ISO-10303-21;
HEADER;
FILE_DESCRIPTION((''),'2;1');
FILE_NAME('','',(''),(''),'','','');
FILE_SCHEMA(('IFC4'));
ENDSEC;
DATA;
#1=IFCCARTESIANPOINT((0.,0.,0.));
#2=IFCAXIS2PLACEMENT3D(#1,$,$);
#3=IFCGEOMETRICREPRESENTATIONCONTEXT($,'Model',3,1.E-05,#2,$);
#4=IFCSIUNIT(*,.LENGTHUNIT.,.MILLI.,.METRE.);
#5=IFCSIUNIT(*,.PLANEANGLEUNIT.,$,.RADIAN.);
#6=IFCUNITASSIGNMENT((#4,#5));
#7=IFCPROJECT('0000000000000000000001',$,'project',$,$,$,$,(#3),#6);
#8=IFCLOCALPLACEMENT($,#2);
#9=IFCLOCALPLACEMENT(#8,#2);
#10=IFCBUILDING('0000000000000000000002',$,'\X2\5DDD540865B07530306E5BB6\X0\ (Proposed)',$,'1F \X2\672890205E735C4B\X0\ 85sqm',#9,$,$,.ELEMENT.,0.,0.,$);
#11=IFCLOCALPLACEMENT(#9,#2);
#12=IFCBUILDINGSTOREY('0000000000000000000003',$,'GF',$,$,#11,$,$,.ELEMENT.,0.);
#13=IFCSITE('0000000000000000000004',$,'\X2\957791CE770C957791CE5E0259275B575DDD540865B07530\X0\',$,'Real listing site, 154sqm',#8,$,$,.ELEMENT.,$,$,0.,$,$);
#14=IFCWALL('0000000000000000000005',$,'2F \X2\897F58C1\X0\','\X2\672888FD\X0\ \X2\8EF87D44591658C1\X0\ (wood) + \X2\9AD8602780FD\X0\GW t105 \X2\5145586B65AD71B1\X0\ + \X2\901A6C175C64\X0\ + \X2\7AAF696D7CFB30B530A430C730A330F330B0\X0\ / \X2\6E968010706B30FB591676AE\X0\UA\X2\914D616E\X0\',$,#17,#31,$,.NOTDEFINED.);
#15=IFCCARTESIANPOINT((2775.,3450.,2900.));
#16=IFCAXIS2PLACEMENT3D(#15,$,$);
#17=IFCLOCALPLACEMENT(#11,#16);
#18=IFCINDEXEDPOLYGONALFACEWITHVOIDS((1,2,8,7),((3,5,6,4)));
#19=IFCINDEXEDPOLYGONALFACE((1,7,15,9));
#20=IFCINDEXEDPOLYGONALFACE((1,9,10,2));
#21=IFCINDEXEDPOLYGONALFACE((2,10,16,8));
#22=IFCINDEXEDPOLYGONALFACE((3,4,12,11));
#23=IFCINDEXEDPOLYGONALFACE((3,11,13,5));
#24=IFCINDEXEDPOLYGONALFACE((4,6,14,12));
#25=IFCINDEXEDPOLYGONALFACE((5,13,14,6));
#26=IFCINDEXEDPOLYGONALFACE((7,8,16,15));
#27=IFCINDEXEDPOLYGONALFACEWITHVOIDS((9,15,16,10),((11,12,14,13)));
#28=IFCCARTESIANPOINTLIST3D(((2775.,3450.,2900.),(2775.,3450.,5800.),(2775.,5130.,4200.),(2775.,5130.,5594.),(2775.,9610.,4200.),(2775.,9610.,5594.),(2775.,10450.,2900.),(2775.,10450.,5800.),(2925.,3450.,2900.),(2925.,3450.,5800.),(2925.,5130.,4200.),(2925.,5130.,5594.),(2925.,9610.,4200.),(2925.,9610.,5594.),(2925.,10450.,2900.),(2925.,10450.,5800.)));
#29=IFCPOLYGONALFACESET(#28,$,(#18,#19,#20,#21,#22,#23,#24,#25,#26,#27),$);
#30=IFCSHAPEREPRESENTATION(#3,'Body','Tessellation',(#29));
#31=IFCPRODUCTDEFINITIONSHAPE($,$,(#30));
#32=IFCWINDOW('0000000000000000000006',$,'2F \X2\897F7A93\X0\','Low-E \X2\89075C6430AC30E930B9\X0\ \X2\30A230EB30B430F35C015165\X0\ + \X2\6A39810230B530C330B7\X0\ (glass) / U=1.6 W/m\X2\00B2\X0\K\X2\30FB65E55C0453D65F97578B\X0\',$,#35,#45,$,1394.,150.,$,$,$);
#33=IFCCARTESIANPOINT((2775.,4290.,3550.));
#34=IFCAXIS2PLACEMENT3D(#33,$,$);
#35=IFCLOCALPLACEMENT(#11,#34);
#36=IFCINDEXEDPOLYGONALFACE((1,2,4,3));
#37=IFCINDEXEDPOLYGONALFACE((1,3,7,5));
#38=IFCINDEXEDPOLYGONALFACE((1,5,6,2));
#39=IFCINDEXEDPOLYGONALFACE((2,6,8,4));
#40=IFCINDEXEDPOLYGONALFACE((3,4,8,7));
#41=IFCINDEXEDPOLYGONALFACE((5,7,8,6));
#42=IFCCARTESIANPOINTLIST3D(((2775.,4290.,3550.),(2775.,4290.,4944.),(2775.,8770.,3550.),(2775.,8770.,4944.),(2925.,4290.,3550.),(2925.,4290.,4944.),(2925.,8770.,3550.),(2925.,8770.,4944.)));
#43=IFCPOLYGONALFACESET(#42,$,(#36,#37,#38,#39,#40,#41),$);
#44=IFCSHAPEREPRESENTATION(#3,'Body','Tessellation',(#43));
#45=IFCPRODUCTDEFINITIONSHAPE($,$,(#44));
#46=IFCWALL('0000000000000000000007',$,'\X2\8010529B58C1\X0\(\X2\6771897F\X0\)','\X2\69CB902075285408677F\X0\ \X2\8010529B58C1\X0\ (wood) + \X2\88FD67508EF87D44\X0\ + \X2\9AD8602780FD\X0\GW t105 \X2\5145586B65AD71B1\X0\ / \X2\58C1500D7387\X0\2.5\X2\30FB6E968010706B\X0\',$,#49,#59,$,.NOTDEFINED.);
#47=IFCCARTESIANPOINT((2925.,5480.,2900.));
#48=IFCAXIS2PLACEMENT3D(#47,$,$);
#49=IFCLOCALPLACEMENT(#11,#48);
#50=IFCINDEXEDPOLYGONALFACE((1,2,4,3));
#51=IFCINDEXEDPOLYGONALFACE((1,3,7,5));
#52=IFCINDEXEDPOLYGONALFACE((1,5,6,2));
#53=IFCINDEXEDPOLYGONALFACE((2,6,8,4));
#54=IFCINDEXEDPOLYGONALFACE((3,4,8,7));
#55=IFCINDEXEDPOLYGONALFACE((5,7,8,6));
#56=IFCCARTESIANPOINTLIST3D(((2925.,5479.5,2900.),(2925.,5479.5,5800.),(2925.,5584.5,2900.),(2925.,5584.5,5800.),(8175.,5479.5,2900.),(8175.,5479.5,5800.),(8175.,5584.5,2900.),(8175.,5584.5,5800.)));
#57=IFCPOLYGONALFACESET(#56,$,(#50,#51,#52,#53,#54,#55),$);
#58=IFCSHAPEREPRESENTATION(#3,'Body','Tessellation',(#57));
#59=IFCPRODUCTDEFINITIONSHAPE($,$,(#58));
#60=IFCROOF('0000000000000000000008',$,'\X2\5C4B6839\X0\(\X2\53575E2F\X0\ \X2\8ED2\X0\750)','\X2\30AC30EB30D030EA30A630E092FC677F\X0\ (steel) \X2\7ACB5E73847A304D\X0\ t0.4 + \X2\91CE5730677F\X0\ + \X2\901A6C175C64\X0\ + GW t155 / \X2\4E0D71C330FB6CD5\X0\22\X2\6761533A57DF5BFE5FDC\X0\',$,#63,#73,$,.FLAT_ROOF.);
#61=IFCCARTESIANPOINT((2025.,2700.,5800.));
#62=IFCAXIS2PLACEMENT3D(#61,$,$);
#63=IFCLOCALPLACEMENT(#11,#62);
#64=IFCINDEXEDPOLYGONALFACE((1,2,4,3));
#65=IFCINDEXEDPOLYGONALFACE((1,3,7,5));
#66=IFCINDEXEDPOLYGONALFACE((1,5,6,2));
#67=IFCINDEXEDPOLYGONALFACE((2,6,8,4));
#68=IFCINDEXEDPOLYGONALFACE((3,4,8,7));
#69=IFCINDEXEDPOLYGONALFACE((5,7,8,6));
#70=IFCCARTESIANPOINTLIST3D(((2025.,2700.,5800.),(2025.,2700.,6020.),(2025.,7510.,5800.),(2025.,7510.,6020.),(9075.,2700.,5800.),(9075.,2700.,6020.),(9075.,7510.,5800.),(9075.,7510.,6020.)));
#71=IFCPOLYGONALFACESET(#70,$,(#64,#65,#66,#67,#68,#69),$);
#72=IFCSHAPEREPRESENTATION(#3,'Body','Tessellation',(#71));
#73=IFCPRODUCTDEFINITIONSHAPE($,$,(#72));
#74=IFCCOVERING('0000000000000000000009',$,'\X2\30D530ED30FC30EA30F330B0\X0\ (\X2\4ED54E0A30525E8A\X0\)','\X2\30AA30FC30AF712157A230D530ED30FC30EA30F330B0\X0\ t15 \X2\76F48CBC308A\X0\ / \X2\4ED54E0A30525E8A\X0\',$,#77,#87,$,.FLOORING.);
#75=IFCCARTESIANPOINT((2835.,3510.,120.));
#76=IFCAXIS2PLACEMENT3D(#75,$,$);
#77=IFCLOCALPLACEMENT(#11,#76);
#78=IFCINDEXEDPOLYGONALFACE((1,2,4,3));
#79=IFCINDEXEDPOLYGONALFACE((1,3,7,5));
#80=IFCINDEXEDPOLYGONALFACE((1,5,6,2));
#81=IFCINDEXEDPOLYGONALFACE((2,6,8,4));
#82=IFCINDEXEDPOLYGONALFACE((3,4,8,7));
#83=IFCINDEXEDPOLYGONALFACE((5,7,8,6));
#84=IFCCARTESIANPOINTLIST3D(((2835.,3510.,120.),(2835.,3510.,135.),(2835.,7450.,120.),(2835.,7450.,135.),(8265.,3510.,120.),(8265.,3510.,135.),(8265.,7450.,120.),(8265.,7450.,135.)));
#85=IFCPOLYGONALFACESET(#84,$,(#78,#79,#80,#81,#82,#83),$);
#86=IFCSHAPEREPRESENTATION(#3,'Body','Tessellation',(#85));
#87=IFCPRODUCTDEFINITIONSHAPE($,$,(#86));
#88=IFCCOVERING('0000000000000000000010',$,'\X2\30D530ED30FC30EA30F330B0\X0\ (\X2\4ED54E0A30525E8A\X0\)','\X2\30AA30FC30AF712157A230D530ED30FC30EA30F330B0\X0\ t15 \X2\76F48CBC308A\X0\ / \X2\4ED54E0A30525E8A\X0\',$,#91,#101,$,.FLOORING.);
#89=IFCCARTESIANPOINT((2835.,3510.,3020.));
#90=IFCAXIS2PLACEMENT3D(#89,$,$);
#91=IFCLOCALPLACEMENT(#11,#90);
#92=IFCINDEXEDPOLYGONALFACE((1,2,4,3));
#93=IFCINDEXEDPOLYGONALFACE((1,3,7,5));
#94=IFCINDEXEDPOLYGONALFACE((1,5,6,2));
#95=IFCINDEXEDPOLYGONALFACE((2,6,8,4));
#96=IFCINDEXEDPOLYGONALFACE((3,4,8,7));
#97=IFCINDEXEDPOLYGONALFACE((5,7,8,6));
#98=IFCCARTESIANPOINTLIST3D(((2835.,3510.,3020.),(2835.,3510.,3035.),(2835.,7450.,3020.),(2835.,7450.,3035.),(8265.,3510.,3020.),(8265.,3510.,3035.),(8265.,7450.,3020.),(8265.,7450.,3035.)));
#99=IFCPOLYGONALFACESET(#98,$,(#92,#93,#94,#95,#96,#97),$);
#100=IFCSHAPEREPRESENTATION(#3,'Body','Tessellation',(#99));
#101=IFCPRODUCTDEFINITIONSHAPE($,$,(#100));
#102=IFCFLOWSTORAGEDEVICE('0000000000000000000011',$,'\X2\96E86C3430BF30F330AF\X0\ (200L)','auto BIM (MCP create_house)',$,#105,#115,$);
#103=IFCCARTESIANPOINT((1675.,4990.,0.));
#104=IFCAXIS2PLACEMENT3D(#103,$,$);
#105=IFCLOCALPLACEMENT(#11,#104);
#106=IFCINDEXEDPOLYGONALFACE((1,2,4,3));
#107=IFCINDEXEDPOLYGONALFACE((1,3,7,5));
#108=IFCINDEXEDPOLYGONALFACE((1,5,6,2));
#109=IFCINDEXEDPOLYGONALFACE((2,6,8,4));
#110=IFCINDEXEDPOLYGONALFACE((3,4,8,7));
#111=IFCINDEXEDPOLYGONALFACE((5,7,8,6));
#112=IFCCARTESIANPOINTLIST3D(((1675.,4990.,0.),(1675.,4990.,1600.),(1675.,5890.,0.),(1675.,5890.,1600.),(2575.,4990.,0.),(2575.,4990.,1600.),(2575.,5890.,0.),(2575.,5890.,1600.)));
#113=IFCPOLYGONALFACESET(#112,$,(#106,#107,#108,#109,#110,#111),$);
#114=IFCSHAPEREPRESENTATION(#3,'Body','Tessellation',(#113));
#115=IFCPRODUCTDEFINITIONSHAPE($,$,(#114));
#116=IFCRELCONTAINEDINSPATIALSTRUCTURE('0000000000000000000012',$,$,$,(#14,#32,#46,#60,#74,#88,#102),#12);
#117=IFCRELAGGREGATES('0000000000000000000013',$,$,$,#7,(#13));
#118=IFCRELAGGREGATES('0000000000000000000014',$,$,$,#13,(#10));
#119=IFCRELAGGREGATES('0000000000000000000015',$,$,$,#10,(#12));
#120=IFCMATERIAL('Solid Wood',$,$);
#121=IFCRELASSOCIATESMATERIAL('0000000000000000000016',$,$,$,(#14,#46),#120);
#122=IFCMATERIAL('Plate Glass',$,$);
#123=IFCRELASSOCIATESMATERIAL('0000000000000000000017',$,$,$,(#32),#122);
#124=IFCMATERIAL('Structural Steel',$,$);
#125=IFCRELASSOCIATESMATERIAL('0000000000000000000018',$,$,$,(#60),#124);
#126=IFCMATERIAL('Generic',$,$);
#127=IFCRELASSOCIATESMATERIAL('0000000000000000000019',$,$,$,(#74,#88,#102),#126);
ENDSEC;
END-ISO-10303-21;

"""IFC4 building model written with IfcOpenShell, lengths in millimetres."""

from ifc_helpers import new_model, si_unit, frame, frame_2d, origin, place, context, project, spatial, rectangle, extrude, material, element, fill, save


model = new_model("IFC4")

# Units and contexts
model_context = context("Model", 3, precision=1e-05, world=origin())
ifc_project = project(units=[si_unit("LENGTHUNIT", "METRE", prefix="MILLI"), si_unit("PLANEANGLEUNIT", "RADIAN")], contexts=[model_context])

# Site, building, storey
site_placement = place(None, origin())
site = spatial("IfcSite", under=ifc_project, at=site_placement, Name="長野県長野市大字川合新田", ObjectType="Real listing site, 154sqm", CompositionType="ELEMENT", RefElevation=0.0)
building_placement = place(site_placement, origin())
building = spatial("IfcBuilding", under=site, at=building_placement, Name="川合新田の家 (Proposed)", ObjectType="1F 木造平屋 85sqm", CompositionType="ELEMENT", ElevationOfRefHeight=0.0, ElevationOfTerrain=0.0)
storey_placement = place(building_placement, origin())
storey = spatial("IfcBuildingStorey", under=building, at=storey_placement, Name="GF", CompositionType="ELEMENT", Elevation=0.0)

# Shared definitions
ifc_material_1 = material(Name="Solid Wood")
ifc_material_2 = material(Name="Generic")

# Shared definitions
ifc_material_3 = material(Name="Plate Glass")

# Wall, opening, window
wall_1_placement = place(storey_placement, frame((2775.0, 3450.0, 2900.0)))
wall_1 = element("IfcWall", 1, at=wall_1_placement, inside=storey, material=ifc_material_1, Name="2F 西壁", Description="木製 軸組外壁 (wood) + 高性能GW t105 充填断熱 + 通気層 + 窯業系サイディング / 準耐火・外皮UA配慮", PredefinedType="NOTDEFINED", context=model_context, shape_type="SweptSolid", body=[
    extrude(rectangle(XDim=150.0, YDim=7000.0, at=frame_2d((75.0, 3500.0))), frame((2775.0, 3450.0, 2900.0)), (0.0, 0.0, 1.0), 2900.0),
])
opening_1_placement = place(storey_placement, frame((2775.0, 4290.0, 3550.0)))
opening_1 = element("IfcOpeningElement", 2, at=opening_1_placement, cuts=wall_1, PredefinedType="NOTDEFINED", context=model_context, shape_type="SweptSolid", body=[
    extrude(rectangle(XDim=150.0, YDim=4480.0, at=frame_2d((75.0, 2240.0))), frame((2775.0, 4290.0, 3550.0)), (0.0, 0.0, 1.0), 1394.0),
])
window_1_placement = place(storey_placement, frame((2775.0, 4290.0, 3550.0)))
window_1 = element("IfcWindow", 3, at=window_1_placement, inside=storey, material=ifc_material_3, Name="2F 西窓", Description="Low-E 複層ガラス アルゴン封入 + 樹脂サッシ (glass) / U=1.6 W/m²K・日射取得型", OverallHeight=1394.0, OverallWidth=150.0, context=model_context, shape_type="SweptSolid", body=[
    extrude(rectangle(XDim=150.0, YDim=4480.0, at=frame_2d((75.0, 2240.0))), frame((2775.0, 4290.0, 3550.0)), (0.0, 0.0, 1.0), 1394.0),
])
fill(opening_1, window_1)

# Wall
wall_2_placement = place(storey_placement, frame((2925.0, 5480.0, 2900.0)))
element("IfcWall", 4, at=wall_2_placement, inside=storey, material=ifc_material_1, Name="耐力壁(東西)", Description="構造用合板 耐力壁 (wood) + 製材軸組 + 高性能GW t105 充填断熱 / 壁倍率2.5・準耐火", PredefinedType="NOTDEFINED", context=model_context, shape_type="SweptSolid", body=[
    extrude(rectangle(XDim=5250.0, YDim=105.0, at=frame_2d((2625.0, 52.0))), frame((2925.0, 5480.0, 2900.0)), (0.0, 0.0, 1.0), 2900.0),
])

# Roof
ifc_material_4 = material(Name="Structural Steel")
for number, where, name in (
    (5, (2025.0, 2700.0, 5800.0), "屋根(南帯 軒750)"),
):
    element("IfcRoof", number, at=place(storey_placement, frame(where)), inside=storey, material=ifc_material_4, Name=name, Description="ガルバリウム鋼板 (steel) 立平葺き t0.4 + 野地板 + 通気層 + GW t155 / 不燃・法22条区域対応", PredefinedType="FLAT_ROOF", context=model_context, shape_type="SweptSolid", body=[
        extrude(rectangle(XDim=7050.0, YDim=4810.0, at=frame_2d((3525.0, 2405.0))), frame((2025.0, 2700.0, 5800.0)), (0.0, 0.0, 1.0), 220.0),
    ])

# Coverings
covering_1_placement = place(storey_placement, frame((2835.0, 3510.0, 120.0)))
element("IfcCovering", 6, at=covering_1_placement, inside=storey, material=ifc_material_2, Name="フローリング (仕上げ床)", Description="オーク無垢フローリング t15 直貼り / 仕上げ床", PredefinedType="FLOORING", context=model_context, shape_type="SweptSolid", body=[
    extrude(rectangle(XDim=5430.0, YDim=3940.0, at=frame_2d((2715.0, 1970.0))), frame((2835.0, 3510.0, 120.0)), (0.0, 0.0, 1.0), 15.0),
])
covering_2_placement = place(storey_placement, frame((2835.0, 3510.0, 3020.0)))
element("IfcCovering", 7, at=covering_2_placement, inside=storey, material=ifc_material_2, Name="フローリング (仕上げ床)", Description="オーク無垢フローリング t15 直貼り / 仕上げ床", PredefinedType="FLOORING", context=model_context, shape_type="SweptSolid", body=[
    extrude(rectangle(XDim=5430.0, YDim=3940.0, at=frame_2d((2715.0, 1970.0))), frame((2835.0, 3510.0, 3020.0)), (0.0, 0.0, 1.0), 15.0),
])

# Flow storage device
flow_storage_device_placement = place(storey_placement, frame((1675.0, 4990.0, 0.0)))
element("IfcFlowStorageDevice", 8, at=flow_storage_device_placement, inside=storey, material=ifc_material_2, Name="雨水タンク (200L)", Description="auto BIM (MCP create_house)", context=model_context, shape_type="SweptSolid", body=[
    extrude(rectangle(XDim=900.0, YDim=900.0, at=frame_2d((450.0, 450.0))), frame((1675.0, 4990.0, 0.0)), (0.0, 0.0, 1.0), 1600.0),
])

save(model, "model.ifc")
